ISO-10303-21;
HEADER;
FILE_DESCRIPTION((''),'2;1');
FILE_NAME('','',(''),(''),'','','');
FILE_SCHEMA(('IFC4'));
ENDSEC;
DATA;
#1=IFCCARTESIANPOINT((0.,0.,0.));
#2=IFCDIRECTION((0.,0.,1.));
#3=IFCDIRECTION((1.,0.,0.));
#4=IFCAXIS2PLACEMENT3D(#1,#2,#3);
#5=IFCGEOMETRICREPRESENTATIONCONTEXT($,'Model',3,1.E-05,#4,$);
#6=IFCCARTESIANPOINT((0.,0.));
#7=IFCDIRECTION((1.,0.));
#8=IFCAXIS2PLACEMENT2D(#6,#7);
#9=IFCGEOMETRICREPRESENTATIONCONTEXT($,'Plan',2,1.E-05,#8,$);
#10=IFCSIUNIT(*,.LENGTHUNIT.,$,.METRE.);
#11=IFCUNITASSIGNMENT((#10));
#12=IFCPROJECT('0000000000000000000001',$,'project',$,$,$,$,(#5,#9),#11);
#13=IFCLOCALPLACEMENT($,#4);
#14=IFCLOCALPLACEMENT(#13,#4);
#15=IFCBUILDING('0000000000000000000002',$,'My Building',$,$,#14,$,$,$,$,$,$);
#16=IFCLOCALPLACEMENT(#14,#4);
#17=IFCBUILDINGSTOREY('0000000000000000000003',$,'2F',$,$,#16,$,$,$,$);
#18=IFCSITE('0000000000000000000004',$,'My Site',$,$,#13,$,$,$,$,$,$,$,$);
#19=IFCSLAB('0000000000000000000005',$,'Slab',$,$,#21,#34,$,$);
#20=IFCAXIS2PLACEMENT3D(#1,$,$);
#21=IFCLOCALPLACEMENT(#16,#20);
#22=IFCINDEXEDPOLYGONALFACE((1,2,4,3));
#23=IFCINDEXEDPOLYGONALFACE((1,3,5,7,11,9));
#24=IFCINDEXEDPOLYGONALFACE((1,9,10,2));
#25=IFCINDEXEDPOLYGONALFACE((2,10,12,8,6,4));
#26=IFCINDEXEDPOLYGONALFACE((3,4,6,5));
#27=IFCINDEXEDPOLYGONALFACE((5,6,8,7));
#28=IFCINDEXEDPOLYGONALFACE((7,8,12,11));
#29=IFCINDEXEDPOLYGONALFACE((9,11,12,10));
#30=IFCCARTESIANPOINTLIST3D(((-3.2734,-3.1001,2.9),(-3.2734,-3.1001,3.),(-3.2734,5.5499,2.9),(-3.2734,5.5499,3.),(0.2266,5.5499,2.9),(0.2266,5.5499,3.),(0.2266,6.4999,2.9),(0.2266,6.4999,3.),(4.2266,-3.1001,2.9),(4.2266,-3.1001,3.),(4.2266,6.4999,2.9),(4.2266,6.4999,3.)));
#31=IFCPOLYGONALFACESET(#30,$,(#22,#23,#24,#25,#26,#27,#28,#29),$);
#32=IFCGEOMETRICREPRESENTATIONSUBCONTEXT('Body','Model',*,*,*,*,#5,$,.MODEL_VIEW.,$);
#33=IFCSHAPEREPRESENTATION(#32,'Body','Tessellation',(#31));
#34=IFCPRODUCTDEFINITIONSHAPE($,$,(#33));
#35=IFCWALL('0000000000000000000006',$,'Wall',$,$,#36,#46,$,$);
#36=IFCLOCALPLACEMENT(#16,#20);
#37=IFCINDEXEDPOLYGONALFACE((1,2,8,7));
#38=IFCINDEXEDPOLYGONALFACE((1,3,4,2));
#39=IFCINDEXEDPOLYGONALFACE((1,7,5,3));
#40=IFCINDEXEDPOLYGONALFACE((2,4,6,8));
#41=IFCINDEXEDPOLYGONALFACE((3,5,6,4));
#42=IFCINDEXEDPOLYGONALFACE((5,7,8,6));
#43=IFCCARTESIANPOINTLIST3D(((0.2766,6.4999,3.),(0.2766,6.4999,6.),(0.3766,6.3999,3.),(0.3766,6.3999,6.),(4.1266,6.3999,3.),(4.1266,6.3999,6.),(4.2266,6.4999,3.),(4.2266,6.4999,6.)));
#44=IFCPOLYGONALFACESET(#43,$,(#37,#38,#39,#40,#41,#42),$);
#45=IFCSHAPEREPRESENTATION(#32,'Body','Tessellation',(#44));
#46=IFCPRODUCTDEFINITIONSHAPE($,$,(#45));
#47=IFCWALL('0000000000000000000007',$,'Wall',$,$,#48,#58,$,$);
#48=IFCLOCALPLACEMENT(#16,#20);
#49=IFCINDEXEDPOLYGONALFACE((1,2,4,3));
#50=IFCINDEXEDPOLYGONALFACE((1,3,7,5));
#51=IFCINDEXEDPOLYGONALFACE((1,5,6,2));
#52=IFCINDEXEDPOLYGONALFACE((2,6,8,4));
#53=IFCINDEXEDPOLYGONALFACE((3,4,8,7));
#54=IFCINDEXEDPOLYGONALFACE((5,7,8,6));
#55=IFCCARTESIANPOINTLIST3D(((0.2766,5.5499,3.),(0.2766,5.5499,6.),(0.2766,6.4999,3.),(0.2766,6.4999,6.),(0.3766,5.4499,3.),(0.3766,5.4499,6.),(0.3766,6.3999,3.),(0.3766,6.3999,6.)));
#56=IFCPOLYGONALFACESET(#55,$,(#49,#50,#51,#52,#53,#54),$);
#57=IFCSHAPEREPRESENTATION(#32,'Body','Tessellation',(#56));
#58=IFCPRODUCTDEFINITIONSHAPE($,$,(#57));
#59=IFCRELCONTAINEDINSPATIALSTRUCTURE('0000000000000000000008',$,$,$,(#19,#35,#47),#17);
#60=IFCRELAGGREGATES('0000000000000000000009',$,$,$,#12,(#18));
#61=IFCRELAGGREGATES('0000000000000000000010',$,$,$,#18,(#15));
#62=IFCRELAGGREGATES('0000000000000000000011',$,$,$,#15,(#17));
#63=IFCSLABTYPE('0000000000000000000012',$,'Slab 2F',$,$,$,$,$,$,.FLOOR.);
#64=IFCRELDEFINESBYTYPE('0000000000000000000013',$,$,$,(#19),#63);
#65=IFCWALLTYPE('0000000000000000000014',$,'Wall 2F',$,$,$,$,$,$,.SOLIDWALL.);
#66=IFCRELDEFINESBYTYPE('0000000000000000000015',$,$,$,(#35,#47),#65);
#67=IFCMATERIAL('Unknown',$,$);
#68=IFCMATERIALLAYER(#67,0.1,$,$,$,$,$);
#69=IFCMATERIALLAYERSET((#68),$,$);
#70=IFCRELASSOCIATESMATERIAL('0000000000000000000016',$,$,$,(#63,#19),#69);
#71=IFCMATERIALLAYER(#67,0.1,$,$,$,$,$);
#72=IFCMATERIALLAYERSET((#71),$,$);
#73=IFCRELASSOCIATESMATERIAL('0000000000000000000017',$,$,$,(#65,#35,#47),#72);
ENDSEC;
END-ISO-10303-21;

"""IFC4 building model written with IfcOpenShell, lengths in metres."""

from ifc_helpers import new_model, si_unit, frame, origin_with_axes, origin_2d_with_axis, place, context, subcontext, project, spatial, line, indexed_curve, outline, extrude, material, layer, layer_set, layer_usage, type_object, element, save


model = new_model("IFC4")

# Units and contexts
model_context = context("Model", 3, precision=1e-05, world=origin_with_axes())
plan_context = context("Plan", 2, precision=1e-05, world=origin_2d_with_axis())
body_context_1 = subcontext(model_context, "Body", "Model", "MODEL_VIEW")
ifc_project = project(units=[si_unit("LENGTHUNIT", "METRE")], contexts=[model_context, plan_context])

# Site, building, storey
site_placement = place(None, origin_with_axes())
site = spatial("IfcSite", under=ifc_project, at=site_placement, Name="My Site")
building_placement = place(site_placement, origin_with_axes())
building = spatial("IfcBuilding", under=site, at=building_placement, Name="My Building")
storey_placement = place(building_placement, origin_with_axes())
storey = spatial("IfcBuildingStorey", under=building, at=storey_placement, Name="2F")

# Slab
ifc_material = material(Name="Unknown")
ifc_layer_1 = layer(ifc_material, 0.1)
ifc_layer_set_1 = layer_set([ifc_layer_1])
ifc_layer_usage_1 = layer_usage(ifc_layer_set_1, "AXIS3", "POSITIVE", -0.1)
slab_type = type_object("IfcSlabType", Name="Slab 2F", PredefinedType="FLOOR", material=ifc_layer_set_1)
slab_placement = place(storey_placement, frame((4.2266, -3.1001, 3.0), z_axis=(0.0, 0.0, 1.0), x_axis=(1.0, 0.0, 0.0)))
element("IfcSlab", 1, at=slab_placement, inside=storey, type_object=slab_type, material=ifc_layer_usage_1, Name="Slab", context=body_context_1, shape_type="SweptSolid", body=[
    extrude(outline(indexed_curve([(0.0, 0.0), (-7.5, 0.0), (-7.5, 8.65), (-4.0, 8.65), (-4.0, 9.6), (0.0, 9.6), (0.0, 0.0)])), frame((0.0, 0.0, -0.1), z_axis=(0.0, 0.0, 1.0), x_axis=(1.0, 0.0, 0.0)), (0.0, 0.0, 1.0), 0.1),
])

# Walls
ifc_layer_2 = layer(ifc_material, 0.1)
ifc_layer_set_2 = layer_set([ifc_layer_2])
ifc_layer_usage_2 = layer_usage(ifc_layer_set_2, "AXIS2", "POSITIVE", 0.0)
wall_type = type_object("IfcWallType", Name="Wall 2F", PredefinedType="SOLIDWALL", material=ifc_layer_set_2)
wall_1_placement = place(storey_placement, frame((4.2266, 6.4999, 3.0), z_axis=(0.0, 0.0, 1.0), x_axis=(-1.0, 0.0, 0.0)))
element("IfcWall", 2, at=wall_1_placement, inside=storey, type_object=wall_type, material=ifc_layer_usage_2, Name="Wall", context=body_context_1, shape_type="SweptSolid", body=[
    extrude(outline(indexed_curve([(0.0, 0.0), (0.1, 0.1), (3.85, 0.1), (3.95, 0.0)], segments=[line(1, 2, 3, 4, 1)])), origin_with_axes(), (0.0, 0.0, 1.0), 3.0),
])
ifc_layer_usage_3 = layer_usage(ifc_layer_set_2, "AXIS2", "POSITIVE", 0.0)
wall_2_placement = place(storey_placement, frame((0.2766, 6.4999, 3.0), z_axis=(0.0, 0.0, 1.0), x_axis=(0.0, -1.0, 0.0)))
element("IfcWall", 3, at=wall_2_placement, inside=storey, type_object=wall_type, material=ifc_layer_usage_3, Name="Wall", context=body_context_1, shape_type="SweptSolid", body=[
    extrude(outline(indexed_curve([(0.0, 0.0), (0.1, 0.1), (1.05, 0.1), (0.95, 0.0)], segments=[line(1, 2, 3, 4, 1)])), origin_with_axes(), (0.0, 0.0, 1.0), 3.0),
])

save(model, "model.ifc")
